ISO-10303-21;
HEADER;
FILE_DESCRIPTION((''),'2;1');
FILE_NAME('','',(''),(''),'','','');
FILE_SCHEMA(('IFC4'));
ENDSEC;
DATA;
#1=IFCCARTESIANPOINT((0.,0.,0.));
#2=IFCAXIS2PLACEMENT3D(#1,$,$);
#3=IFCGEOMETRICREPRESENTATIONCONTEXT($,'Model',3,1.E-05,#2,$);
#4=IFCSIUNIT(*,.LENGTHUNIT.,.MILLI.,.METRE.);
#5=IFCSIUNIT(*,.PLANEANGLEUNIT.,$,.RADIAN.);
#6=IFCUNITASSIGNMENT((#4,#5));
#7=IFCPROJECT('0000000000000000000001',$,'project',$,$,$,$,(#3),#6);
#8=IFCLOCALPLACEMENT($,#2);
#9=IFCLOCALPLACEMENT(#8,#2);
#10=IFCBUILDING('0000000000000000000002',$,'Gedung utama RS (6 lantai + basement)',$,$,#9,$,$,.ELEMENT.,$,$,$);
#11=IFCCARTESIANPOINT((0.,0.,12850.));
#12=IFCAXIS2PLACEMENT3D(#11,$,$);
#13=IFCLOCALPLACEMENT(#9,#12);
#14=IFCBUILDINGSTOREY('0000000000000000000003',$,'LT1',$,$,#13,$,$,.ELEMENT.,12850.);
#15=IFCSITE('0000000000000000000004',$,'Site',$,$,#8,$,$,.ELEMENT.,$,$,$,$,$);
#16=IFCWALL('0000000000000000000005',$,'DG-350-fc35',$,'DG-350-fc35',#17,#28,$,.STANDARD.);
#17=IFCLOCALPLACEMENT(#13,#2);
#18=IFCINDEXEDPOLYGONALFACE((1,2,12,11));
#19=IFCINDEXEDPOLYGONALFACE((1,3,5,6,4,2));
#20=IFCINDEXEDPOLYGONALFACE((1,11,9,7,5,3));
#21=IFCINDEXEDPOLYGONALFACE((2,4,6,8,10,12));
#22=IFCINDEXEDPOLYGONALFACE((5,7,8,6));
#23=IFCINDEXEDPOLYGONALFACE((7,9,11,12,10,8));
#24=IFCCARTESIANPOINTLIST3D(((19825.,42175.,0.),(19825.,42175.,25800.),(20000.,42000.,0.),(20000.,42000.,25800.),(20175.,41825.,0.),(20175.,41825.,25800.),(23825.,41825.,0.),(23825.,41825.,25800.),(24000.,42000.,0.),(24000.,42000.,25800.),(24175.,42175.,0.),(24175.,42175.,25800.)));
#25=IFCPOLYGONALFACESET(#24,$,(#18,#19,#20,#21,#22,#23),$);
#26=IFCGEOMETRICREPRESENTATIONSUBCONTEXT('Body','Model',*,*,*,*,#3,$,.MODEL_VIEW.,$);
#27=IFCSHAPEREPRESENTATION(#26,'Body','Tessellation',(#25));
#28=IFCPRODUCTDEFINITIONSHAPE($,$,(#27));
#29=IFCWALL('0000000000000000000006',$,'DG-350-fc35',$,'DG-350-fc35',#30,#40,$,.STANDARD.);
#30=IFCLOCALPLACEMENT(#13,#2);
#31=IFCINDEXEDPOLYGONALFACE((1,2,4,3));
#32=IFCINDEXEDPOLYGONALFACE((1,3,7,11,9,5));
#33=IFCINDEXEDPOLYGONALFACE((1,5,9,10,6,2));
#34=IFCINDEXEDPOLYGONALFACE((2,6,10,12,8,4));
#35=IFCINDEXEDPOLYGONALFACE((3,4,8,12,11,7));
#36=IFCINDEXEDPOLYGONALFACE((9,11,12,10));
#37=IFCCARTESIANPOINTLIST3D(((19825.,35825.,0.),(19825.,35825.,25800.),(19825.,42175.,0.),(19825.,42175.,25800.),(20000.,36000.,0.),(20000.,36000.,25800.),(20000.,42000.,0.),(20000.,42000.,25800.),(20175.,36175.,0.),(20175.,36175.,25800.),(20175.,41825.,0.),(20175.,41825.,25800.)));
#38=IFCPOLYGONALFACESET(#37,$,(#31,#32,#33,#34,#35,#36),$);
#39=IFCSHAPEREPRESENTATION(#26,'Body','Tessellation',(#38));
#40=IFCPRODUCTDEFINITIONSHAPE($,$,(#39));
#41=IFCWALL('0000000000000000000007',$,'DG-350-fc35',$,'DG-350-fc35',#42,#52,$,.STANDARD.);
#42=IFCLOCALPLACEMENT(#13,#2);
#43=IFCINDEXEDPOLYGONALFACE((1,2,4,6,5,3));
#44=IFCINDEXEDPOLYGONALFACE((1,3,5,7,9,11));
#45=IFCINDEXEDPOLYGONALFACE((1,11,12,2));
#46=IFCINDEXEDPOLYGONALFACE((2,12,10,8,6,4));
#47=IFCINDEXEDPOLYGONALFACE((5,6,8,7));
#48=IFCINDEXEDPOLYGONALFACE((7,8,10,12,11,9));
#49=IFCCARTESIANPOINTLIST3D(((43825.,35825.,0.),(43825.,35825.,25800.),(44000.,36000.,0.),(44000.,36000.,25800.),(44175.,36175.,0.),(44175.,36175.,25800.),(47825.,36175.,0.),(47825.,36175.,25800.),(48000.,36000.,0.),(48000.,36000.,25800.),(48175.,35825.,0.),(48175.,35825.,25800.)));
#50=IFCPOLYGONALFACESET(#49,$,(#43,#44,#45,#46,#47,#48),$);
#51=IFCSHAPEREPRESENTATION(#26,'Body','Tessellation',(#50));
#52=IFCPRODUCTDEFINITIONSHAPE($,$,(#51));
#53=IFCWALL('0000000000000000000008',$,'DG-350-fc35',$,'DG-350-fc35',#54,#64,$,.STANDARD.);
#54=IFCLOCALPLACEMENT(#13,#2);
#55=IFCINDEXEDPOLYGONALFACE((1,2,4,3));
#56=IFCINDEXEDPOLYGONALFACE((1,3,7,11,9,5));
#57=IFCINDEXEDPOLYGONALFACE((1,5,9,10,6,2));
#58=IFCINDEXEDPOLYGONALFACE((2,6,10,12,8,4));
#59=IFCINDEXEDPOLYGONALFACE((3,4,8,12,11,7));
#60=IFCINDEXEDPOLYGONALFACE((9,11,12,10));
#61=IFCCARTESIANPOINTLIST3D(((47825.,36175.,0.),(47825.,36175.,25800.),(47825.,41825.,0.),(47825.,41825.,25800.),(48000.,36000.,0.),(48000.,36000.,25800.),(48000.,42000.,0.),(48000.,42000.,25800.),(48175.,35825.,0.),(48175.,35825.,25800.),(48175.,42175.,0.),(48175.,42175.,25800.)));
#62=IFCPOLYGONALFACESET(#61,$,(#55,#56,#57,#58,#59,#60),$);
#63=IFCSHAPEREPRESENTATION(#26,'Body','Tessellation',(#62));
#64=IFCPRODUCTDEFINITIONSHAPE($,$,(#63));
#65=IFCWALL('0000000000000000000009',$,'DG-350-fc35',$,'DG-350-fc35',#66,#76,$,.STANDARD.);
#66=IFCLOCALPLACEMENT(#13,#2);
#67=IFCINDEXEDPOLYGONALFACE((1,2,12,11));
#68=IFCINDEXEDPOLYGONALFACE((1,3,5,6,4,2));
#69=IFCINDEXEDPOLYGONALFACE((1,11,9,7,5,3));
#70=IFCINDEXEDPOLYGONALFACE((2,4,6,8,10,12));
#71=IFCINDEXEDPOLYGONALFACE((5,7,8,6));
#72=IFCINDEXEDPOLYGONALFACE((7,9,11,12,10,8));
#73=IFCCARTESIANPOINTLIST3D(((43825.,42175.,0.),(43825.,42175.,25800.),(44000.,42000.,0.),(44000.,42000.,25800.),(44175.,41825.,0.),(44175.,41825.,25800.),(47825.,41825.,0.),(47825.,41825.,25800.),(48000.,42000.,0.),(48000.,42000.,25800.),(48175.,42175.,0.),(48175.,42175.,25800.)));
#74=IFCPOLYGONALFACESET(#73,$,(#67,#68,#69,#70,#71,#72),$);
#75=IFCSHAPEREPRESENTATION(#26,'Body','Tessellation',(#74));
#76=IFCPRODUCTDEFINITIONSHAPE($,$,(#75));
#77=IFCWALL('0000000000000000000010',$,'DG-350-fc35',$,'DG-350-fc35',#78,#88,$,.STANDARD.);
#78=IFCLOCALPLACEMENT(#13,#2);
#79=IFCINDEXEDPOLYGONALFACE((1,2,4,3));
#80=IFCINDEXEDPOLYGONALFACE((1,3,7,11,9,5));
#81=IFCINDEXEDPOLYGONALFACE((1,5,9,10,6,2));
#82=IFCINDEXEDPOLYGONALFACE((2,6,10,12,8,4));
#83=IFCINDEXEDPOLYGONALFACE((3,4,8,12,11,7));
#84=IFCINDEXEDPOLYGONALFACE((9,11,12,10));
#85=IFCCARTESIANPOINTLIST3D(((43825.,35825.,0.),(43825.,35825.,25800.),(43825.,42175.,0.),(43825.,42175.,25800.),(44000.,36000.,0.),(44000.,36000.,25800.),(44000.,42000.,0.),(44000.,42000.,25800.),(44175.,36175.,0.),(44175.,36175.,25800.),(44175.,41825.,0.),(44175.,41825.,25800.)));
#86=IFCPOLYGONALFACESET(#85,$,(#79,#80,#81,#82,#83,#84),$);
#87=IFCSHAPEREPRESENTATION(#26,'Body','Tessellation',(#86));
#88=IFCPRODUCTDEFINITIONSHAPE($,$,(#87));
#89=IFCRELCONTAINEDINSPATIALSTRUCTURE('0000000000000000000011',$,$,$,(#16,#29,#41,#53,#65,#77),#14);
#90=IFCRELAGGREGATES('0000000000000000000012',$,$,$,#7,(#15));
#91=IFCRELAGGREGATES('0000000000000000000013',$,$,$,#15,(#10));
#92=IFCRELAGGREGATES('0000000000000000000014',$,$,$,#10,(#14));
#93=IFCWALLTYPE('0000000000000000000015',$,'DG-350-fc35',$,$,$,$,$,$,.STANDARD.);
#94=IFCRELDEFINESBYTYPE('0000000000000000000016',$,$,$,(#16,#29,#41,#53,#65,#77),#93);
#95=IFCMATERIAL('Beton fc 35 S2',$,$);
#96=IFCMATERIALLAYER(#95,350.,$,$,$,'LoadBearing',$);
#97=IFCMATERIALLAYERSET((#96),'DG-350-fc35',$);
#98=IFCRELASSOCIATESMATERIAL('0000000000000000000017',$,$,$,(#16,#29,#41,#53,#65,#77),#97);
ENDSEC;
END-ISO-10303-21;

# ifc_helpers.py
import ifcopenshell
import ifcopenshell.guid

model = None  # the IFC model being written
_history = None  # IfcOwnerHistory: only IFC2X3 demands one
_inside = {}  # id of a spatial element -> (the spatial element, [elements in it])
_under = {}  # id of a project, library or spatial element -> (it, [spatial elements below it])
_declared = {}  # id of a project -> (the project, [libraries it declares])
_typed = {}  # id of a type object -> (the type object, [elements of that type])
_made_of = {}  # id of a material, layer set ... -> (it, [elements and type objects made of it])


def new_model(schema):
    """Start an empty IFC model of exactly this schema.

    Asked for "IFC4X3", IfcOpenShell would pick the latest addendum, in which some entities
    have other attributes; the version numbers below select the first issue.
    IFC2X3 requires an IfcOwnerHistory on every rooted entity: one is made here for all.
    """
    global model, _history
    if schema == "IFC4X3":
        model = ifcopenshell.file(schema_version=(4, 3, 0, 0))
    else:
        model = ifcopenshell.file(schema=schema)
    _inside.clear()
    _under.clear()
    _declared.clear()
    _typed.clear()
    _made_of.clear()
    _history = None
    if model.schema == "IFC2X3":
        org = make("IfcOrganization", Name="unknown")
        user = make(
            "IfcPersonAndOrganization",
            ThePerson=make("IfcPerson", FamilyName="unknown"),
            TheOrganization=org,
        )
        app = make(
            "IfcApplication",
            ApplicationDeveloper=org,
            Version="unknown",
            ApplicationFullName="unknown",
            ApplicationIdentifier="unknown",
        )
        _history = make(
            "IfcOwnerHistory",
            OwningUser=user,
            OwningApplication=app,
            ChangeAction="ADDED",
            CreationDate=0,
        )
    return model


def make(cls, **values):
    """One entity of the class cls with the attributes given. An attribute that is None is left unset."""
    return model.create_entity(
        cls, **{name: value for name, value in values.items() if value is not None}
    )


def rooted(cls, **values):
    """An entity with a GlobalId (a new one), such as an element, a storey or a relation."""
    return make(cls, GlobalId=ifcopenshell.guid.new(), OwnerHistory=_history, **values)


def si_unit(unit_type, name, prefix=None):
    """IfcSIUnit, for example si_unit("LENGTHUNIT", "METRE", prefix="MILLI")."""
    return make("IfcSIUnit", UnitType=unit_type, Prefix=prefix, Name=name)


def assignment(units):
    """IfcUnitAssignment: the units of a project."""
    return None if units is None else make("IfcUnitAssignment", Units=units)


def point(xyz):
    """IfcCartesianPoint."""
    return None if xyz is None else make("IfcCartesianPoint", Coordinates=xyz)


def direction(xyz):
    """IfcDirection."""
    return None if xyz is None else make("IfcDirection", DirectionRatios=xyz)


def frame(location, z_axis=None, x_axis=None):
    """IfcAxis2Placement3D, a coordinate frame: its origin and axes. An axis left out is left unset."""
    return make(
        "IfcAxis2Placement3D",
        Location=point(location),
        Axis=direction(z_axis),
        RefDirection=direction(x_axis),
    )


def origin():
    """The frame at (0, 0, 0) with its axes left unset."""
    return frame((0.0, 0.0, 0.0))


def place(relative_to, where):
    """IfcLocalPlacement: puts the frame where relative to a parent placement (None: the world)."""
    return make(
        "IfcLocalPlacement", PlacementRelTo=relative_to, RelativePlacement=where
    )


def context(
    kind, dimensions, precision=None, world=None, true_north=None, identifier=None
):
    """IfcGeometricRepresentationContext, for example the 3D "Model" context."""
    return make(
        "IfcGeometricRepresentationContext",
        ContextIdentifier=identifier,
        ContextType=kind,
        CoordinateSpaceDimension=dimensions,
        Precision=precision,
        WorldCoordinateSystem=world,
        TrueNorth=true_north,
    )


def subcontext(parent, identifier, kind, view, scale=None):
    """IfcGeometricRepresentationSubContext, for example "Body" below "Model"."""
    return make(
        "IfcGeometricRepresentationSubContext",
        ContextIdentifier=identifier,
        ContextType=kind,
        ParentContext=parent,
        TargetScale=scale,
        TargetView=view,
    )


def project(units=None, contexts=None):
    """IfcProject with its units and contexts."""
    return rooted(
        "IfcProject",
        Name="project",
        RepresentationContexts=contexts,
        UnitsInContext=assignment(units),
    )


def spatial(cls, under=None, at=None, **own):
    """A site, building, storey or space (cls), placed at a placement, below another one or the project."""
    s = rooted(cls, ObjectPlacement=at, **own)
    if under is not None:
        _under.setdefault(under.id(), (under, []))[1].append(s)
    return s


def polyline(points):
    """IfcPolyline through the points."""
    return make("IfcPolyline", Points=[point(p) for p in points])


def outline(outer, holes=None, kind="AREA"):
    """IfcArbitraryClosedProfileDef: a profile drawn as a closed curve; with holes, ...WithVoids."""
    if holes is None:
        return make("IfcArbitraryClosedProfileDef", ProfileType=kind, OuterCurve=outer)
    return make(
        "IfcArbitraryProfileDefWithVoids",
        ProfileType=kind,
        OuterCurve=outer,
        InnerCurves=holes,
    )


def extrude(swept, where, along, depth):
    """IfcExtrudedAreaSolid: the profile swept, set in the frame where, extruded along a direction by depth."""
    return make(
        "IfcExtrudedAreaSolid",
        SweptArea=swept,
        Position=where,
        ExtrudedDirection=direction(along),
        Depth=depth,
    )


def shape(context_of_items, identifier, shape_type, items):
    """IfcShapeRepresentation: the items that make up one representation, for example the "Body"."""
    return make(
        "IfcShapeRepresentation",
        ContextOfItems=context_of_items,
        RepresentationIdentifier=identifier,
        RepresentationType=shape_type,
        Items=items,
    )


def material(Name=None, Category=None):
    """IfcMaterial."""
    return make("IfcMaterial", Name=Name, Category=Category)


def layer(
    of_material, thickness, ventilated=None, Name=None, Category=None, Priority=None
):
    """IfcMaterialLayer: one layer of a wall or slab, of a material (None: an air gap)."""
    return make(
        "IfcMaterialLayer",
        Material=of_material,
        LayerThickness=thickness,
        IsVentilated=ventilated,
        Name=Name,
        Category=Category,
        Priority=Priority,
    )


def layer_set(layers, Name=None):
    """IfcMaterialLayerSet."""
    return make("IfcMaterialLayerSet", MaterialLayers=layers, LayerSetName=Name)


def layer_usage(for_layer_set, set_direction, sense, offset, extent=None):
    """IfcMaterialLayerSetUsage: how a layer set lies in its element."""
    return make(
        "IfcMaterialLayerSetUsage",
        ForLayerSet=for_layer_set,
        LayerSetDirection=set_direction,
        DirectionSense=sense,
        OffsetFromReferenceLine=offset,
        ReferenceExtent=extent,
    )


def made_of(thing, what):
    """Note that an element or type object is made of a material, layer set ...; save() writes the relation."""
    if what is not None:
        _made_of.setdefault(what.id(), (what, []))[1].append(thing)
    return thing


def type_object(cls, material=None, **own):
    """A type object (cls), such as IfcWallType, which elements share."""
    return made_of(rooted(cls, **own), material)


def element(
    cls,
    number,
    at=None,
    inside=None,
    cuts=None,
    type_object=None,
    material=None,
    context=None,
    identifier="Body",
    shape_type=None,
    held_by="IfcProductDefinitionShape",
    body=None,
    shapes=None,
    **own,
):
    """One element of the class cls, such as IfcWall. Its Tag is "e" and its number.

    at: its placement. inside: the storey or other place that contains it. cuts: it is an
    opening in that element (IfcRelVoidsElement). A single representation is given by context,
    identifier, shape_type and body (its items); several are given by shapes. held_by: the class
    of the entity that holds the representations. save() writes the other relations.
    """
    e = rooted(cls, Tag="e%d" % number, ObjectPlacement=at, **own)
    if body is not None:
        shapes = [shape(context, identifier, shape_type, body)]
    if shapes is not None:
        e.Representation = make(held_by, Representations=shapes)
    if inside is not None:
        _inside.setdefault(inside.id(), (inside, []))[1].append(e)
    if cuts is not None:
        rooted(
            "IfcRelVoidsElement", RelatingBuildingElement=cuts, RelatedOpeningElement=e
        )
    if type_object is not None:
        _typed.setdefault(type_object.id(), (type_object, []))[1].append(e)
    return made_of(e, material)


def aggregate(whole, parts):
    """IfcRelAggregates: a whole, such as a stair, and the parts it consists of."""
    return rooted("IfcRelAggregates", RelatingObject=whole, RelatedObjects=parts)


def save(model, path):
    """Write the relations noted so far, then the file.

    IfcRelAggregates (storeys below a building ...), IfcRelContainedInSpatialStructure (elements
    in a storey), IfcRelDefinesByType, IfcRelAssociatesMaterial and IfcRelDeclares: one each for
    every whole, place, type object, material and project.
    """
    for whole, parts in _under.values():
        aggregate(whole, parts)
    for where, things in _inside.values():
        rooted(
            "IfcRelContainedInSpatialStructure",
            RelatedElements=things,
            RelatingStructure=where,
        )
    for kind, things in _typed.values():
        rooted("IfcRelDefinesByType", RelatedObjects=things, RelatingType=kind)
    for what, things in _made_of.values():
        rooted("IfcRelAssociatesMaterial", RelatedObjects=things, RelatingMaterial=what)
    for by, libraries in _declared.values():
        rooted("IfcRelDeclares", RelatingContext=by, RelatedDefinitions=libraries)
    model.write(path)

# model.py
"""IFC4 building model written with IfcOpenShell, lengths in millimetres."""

from ifc_helpers import new_model, si_unit, frame, origin, place, context, subcontext, project, spatial, polyline, outline, extrude, material, layer, layer_set, layer_usage, type_object, element, save


model = new_model("IFC4")

# Units and contexts
model_context = context("Model", 3, precision=1e-05, world=origin())
body_context = subcontext(model_context, "Body", "Model", "MODEL_VIEW")
ifc_project = project(units=[si_unit("LENGTHUNIT", "METRE", prefix="MILLI"), si_unit("PLANEANGLEUNIT", "RADIAN")], contexts=[model_context])

# Site, building, storey
site_placement = place(None, origin())
site = spatial("IfcSite", under=ifc_project, at=site_placement, Name="Site", CompositionType="ELEMENT")
building_placement = place(site_placement, origin())
building = spatial("IfcBuilding", under=site, at=building_placement, Name="Gedung utama RS (6 lantai + basement)", CompositionType="ELEMENT")
storey_placement = place(building_placement, frame((0.0, 0.0, 12850.0)))
storey = spatial("IfcBuildingStorey", under=building, at=storey_placement, Name="LT1", CompositionType="ELEMENT", Elevation=12850.0)

# Walls
ifc_material = material(Name="Beton fc 35 S2")
ifc_layer = layer(ifc_material, 350.0, Category="LoadBearing")
ifc_layer_set = layer_set([ifc_layer], Name="DG-350-fc35")
ifc_layer_usage = layer_usage(ifc_layer_set, "AXIS2", "NEGATIVE", 175.0)
wall_type = type_object("IfcWallType", Name="DG-350-fc35", PredefinedType="STANDARD")
wall_1_placement = place(storey_placement, frame((24000.0, 42000.0, 0.0), z_axis=(0.0, 0.0, 1.0), x_axis=(-1.0, 0.0, 0.0)))
element("IfcWall", 1, at=wall_1_placement, inside=storey, type_object=wall_type, material=ifc_layer_usage, Name="DG-350-fc35", ObjectType="DG-350-fc35", PredefinedType="STANDARD", context=body_context, shape_type="SweptSolid", body=[
    extrude(outline(polyline([(-175.0, -175.0), (0.0, 0.0), (175.0, 175.0), (3825.0, 175.0), (4000.0, 0.0), (4175.0, -175.0), (-175.0, -175.0)])), origin(), (0.0, 0.0, 1.0), 25800.0),
])
wall_2_placement = place(storey_placement, frame((20000.0, 42000.0, 0.0), z_axis=(0.0, 0.0, 1.0), x_axis=(0.0, -1.0, 0.0)))
element("IfcWall", 2, at=wall_2_placement, inside=storey, type_object=wall_type, material=ifc_layer_usage, Name="DG-350-fc35", ObjectType="DG-350-fc35", PredefinedType="STANDARD", context=body_context, shape_type="SweptSolid", body=[
    extrude(outline(polyline([(-175.0, -175.0), (0.0, 0.0), (175.0, 175.0), (5825.0, 175.0), (6000.0, 0.0), (6175.0, -175.0), (-175.0, -175.0)])), origin(), (0.0, 0.0, 1.0), 25800.0),
])
wall_3_placement = place(storey_placement, frame((44000.0, 36000.0, 0.0), z_axis=(0.0, 0.0, 1.0), x_axis=(1.0, 0.0, 0.0)))
element("IfcWall", 3, at=wall_3_placement, inside=storey, type_object=wall_type, material=ifc_layer_usage, Name="DG-350-fc35", ObjectType="DG-350-fc35", PredefinedType="STANDARD", context=body_context, shape_type="SweptSolid", body=[
    extrude(outline(polyline([(-175.0, -175.0), (0.0, 0.0), (175.0, 175.0), (3825.0, 175.0), (4000.0, 0.0), (4175.0, -175.0), (-175.0, -175.0)])), origin(), (0.0, 0.0, 1.0), 25800.0),
])
wall_4_placement = place(storey_placement, frame((48000.0, 36000.0, 0.0), z_axis=(0.0, 0.0, 1.0), x_axis=(0.0, 1.0, 0.0)))
element("IfcWall", 4, at=wall_4_placement, inside=storey, type_object=wall_type, material=ifc_layer_usage, Name="DG-350-fc35", ObjectType="DG-350-fc35", PredefinedType="STANDARD", context=body_context, shape_type="SweptSolid", body=[
    extrude(outline(polyline([(-175.0, -175.0), (0.0, 0.0), (175.0, 175.0), (5825.0, 175.0), (6000.0, 0.0), (6175.0, -175.0), (-175.0, -175.0)])), origin(), (0.0, 0.0, 1.0), 25800.0),
])
wall_5_placement = place(storey_placement, frame((48000.0, 42000.0, 0.0), z_axis=(0.0, 0.0, 1.0), x_axis=(-1.0, 0.0, 0.0)))
element("IfcWall", 5, at=wall_5_placement, inside=storey, type_object=wall_type, material=ifc_layer_usage, Name="DG-350-fc35", ObjectType="DG-350-fc35", PredefinedType="STANDARD", context=body_context, shape_type="SweptSolid", body=[
    extrude(outline(polyline([(-175.0, -175.0), (0.0, 0.0), (175.0, 175.0), (3825.0, 175.0), (4000.0, 0.0), (4175.0, -175.0), (-175.0, -175.0)])), origin(), (0.0, 0.0, 1.0), 25800.0),
])
wall_6_placement = place(storey_placement, frame((44000.0, 42000.0, 0.0), z_axis=(0.0, 0.0, 1.0), x_axis=(0.0, -1.0, 0.0)))
element("IfcWall", 6, at=wall_6_placement, inside=storey, type_object=wall_type, material=ifc_layer_usage, Name="DG-350-fc35", ObjectType="DG-350-fc35", PredefinedType="STANDARD", context=body_context, shape_type="SweptSolid", body=[
    extrude(outline(polyline([(-175.0, -175.0), (0.0, 0.0), (175.0, 175.0), (5825.0, 175.0), (6000.0, 0.0), (6175.0, -175.0), (-175.0, -175.0)])), origin(), (0.0, 0.0, 1.0), 25800.0),
])

save(model, "model.ifc")
